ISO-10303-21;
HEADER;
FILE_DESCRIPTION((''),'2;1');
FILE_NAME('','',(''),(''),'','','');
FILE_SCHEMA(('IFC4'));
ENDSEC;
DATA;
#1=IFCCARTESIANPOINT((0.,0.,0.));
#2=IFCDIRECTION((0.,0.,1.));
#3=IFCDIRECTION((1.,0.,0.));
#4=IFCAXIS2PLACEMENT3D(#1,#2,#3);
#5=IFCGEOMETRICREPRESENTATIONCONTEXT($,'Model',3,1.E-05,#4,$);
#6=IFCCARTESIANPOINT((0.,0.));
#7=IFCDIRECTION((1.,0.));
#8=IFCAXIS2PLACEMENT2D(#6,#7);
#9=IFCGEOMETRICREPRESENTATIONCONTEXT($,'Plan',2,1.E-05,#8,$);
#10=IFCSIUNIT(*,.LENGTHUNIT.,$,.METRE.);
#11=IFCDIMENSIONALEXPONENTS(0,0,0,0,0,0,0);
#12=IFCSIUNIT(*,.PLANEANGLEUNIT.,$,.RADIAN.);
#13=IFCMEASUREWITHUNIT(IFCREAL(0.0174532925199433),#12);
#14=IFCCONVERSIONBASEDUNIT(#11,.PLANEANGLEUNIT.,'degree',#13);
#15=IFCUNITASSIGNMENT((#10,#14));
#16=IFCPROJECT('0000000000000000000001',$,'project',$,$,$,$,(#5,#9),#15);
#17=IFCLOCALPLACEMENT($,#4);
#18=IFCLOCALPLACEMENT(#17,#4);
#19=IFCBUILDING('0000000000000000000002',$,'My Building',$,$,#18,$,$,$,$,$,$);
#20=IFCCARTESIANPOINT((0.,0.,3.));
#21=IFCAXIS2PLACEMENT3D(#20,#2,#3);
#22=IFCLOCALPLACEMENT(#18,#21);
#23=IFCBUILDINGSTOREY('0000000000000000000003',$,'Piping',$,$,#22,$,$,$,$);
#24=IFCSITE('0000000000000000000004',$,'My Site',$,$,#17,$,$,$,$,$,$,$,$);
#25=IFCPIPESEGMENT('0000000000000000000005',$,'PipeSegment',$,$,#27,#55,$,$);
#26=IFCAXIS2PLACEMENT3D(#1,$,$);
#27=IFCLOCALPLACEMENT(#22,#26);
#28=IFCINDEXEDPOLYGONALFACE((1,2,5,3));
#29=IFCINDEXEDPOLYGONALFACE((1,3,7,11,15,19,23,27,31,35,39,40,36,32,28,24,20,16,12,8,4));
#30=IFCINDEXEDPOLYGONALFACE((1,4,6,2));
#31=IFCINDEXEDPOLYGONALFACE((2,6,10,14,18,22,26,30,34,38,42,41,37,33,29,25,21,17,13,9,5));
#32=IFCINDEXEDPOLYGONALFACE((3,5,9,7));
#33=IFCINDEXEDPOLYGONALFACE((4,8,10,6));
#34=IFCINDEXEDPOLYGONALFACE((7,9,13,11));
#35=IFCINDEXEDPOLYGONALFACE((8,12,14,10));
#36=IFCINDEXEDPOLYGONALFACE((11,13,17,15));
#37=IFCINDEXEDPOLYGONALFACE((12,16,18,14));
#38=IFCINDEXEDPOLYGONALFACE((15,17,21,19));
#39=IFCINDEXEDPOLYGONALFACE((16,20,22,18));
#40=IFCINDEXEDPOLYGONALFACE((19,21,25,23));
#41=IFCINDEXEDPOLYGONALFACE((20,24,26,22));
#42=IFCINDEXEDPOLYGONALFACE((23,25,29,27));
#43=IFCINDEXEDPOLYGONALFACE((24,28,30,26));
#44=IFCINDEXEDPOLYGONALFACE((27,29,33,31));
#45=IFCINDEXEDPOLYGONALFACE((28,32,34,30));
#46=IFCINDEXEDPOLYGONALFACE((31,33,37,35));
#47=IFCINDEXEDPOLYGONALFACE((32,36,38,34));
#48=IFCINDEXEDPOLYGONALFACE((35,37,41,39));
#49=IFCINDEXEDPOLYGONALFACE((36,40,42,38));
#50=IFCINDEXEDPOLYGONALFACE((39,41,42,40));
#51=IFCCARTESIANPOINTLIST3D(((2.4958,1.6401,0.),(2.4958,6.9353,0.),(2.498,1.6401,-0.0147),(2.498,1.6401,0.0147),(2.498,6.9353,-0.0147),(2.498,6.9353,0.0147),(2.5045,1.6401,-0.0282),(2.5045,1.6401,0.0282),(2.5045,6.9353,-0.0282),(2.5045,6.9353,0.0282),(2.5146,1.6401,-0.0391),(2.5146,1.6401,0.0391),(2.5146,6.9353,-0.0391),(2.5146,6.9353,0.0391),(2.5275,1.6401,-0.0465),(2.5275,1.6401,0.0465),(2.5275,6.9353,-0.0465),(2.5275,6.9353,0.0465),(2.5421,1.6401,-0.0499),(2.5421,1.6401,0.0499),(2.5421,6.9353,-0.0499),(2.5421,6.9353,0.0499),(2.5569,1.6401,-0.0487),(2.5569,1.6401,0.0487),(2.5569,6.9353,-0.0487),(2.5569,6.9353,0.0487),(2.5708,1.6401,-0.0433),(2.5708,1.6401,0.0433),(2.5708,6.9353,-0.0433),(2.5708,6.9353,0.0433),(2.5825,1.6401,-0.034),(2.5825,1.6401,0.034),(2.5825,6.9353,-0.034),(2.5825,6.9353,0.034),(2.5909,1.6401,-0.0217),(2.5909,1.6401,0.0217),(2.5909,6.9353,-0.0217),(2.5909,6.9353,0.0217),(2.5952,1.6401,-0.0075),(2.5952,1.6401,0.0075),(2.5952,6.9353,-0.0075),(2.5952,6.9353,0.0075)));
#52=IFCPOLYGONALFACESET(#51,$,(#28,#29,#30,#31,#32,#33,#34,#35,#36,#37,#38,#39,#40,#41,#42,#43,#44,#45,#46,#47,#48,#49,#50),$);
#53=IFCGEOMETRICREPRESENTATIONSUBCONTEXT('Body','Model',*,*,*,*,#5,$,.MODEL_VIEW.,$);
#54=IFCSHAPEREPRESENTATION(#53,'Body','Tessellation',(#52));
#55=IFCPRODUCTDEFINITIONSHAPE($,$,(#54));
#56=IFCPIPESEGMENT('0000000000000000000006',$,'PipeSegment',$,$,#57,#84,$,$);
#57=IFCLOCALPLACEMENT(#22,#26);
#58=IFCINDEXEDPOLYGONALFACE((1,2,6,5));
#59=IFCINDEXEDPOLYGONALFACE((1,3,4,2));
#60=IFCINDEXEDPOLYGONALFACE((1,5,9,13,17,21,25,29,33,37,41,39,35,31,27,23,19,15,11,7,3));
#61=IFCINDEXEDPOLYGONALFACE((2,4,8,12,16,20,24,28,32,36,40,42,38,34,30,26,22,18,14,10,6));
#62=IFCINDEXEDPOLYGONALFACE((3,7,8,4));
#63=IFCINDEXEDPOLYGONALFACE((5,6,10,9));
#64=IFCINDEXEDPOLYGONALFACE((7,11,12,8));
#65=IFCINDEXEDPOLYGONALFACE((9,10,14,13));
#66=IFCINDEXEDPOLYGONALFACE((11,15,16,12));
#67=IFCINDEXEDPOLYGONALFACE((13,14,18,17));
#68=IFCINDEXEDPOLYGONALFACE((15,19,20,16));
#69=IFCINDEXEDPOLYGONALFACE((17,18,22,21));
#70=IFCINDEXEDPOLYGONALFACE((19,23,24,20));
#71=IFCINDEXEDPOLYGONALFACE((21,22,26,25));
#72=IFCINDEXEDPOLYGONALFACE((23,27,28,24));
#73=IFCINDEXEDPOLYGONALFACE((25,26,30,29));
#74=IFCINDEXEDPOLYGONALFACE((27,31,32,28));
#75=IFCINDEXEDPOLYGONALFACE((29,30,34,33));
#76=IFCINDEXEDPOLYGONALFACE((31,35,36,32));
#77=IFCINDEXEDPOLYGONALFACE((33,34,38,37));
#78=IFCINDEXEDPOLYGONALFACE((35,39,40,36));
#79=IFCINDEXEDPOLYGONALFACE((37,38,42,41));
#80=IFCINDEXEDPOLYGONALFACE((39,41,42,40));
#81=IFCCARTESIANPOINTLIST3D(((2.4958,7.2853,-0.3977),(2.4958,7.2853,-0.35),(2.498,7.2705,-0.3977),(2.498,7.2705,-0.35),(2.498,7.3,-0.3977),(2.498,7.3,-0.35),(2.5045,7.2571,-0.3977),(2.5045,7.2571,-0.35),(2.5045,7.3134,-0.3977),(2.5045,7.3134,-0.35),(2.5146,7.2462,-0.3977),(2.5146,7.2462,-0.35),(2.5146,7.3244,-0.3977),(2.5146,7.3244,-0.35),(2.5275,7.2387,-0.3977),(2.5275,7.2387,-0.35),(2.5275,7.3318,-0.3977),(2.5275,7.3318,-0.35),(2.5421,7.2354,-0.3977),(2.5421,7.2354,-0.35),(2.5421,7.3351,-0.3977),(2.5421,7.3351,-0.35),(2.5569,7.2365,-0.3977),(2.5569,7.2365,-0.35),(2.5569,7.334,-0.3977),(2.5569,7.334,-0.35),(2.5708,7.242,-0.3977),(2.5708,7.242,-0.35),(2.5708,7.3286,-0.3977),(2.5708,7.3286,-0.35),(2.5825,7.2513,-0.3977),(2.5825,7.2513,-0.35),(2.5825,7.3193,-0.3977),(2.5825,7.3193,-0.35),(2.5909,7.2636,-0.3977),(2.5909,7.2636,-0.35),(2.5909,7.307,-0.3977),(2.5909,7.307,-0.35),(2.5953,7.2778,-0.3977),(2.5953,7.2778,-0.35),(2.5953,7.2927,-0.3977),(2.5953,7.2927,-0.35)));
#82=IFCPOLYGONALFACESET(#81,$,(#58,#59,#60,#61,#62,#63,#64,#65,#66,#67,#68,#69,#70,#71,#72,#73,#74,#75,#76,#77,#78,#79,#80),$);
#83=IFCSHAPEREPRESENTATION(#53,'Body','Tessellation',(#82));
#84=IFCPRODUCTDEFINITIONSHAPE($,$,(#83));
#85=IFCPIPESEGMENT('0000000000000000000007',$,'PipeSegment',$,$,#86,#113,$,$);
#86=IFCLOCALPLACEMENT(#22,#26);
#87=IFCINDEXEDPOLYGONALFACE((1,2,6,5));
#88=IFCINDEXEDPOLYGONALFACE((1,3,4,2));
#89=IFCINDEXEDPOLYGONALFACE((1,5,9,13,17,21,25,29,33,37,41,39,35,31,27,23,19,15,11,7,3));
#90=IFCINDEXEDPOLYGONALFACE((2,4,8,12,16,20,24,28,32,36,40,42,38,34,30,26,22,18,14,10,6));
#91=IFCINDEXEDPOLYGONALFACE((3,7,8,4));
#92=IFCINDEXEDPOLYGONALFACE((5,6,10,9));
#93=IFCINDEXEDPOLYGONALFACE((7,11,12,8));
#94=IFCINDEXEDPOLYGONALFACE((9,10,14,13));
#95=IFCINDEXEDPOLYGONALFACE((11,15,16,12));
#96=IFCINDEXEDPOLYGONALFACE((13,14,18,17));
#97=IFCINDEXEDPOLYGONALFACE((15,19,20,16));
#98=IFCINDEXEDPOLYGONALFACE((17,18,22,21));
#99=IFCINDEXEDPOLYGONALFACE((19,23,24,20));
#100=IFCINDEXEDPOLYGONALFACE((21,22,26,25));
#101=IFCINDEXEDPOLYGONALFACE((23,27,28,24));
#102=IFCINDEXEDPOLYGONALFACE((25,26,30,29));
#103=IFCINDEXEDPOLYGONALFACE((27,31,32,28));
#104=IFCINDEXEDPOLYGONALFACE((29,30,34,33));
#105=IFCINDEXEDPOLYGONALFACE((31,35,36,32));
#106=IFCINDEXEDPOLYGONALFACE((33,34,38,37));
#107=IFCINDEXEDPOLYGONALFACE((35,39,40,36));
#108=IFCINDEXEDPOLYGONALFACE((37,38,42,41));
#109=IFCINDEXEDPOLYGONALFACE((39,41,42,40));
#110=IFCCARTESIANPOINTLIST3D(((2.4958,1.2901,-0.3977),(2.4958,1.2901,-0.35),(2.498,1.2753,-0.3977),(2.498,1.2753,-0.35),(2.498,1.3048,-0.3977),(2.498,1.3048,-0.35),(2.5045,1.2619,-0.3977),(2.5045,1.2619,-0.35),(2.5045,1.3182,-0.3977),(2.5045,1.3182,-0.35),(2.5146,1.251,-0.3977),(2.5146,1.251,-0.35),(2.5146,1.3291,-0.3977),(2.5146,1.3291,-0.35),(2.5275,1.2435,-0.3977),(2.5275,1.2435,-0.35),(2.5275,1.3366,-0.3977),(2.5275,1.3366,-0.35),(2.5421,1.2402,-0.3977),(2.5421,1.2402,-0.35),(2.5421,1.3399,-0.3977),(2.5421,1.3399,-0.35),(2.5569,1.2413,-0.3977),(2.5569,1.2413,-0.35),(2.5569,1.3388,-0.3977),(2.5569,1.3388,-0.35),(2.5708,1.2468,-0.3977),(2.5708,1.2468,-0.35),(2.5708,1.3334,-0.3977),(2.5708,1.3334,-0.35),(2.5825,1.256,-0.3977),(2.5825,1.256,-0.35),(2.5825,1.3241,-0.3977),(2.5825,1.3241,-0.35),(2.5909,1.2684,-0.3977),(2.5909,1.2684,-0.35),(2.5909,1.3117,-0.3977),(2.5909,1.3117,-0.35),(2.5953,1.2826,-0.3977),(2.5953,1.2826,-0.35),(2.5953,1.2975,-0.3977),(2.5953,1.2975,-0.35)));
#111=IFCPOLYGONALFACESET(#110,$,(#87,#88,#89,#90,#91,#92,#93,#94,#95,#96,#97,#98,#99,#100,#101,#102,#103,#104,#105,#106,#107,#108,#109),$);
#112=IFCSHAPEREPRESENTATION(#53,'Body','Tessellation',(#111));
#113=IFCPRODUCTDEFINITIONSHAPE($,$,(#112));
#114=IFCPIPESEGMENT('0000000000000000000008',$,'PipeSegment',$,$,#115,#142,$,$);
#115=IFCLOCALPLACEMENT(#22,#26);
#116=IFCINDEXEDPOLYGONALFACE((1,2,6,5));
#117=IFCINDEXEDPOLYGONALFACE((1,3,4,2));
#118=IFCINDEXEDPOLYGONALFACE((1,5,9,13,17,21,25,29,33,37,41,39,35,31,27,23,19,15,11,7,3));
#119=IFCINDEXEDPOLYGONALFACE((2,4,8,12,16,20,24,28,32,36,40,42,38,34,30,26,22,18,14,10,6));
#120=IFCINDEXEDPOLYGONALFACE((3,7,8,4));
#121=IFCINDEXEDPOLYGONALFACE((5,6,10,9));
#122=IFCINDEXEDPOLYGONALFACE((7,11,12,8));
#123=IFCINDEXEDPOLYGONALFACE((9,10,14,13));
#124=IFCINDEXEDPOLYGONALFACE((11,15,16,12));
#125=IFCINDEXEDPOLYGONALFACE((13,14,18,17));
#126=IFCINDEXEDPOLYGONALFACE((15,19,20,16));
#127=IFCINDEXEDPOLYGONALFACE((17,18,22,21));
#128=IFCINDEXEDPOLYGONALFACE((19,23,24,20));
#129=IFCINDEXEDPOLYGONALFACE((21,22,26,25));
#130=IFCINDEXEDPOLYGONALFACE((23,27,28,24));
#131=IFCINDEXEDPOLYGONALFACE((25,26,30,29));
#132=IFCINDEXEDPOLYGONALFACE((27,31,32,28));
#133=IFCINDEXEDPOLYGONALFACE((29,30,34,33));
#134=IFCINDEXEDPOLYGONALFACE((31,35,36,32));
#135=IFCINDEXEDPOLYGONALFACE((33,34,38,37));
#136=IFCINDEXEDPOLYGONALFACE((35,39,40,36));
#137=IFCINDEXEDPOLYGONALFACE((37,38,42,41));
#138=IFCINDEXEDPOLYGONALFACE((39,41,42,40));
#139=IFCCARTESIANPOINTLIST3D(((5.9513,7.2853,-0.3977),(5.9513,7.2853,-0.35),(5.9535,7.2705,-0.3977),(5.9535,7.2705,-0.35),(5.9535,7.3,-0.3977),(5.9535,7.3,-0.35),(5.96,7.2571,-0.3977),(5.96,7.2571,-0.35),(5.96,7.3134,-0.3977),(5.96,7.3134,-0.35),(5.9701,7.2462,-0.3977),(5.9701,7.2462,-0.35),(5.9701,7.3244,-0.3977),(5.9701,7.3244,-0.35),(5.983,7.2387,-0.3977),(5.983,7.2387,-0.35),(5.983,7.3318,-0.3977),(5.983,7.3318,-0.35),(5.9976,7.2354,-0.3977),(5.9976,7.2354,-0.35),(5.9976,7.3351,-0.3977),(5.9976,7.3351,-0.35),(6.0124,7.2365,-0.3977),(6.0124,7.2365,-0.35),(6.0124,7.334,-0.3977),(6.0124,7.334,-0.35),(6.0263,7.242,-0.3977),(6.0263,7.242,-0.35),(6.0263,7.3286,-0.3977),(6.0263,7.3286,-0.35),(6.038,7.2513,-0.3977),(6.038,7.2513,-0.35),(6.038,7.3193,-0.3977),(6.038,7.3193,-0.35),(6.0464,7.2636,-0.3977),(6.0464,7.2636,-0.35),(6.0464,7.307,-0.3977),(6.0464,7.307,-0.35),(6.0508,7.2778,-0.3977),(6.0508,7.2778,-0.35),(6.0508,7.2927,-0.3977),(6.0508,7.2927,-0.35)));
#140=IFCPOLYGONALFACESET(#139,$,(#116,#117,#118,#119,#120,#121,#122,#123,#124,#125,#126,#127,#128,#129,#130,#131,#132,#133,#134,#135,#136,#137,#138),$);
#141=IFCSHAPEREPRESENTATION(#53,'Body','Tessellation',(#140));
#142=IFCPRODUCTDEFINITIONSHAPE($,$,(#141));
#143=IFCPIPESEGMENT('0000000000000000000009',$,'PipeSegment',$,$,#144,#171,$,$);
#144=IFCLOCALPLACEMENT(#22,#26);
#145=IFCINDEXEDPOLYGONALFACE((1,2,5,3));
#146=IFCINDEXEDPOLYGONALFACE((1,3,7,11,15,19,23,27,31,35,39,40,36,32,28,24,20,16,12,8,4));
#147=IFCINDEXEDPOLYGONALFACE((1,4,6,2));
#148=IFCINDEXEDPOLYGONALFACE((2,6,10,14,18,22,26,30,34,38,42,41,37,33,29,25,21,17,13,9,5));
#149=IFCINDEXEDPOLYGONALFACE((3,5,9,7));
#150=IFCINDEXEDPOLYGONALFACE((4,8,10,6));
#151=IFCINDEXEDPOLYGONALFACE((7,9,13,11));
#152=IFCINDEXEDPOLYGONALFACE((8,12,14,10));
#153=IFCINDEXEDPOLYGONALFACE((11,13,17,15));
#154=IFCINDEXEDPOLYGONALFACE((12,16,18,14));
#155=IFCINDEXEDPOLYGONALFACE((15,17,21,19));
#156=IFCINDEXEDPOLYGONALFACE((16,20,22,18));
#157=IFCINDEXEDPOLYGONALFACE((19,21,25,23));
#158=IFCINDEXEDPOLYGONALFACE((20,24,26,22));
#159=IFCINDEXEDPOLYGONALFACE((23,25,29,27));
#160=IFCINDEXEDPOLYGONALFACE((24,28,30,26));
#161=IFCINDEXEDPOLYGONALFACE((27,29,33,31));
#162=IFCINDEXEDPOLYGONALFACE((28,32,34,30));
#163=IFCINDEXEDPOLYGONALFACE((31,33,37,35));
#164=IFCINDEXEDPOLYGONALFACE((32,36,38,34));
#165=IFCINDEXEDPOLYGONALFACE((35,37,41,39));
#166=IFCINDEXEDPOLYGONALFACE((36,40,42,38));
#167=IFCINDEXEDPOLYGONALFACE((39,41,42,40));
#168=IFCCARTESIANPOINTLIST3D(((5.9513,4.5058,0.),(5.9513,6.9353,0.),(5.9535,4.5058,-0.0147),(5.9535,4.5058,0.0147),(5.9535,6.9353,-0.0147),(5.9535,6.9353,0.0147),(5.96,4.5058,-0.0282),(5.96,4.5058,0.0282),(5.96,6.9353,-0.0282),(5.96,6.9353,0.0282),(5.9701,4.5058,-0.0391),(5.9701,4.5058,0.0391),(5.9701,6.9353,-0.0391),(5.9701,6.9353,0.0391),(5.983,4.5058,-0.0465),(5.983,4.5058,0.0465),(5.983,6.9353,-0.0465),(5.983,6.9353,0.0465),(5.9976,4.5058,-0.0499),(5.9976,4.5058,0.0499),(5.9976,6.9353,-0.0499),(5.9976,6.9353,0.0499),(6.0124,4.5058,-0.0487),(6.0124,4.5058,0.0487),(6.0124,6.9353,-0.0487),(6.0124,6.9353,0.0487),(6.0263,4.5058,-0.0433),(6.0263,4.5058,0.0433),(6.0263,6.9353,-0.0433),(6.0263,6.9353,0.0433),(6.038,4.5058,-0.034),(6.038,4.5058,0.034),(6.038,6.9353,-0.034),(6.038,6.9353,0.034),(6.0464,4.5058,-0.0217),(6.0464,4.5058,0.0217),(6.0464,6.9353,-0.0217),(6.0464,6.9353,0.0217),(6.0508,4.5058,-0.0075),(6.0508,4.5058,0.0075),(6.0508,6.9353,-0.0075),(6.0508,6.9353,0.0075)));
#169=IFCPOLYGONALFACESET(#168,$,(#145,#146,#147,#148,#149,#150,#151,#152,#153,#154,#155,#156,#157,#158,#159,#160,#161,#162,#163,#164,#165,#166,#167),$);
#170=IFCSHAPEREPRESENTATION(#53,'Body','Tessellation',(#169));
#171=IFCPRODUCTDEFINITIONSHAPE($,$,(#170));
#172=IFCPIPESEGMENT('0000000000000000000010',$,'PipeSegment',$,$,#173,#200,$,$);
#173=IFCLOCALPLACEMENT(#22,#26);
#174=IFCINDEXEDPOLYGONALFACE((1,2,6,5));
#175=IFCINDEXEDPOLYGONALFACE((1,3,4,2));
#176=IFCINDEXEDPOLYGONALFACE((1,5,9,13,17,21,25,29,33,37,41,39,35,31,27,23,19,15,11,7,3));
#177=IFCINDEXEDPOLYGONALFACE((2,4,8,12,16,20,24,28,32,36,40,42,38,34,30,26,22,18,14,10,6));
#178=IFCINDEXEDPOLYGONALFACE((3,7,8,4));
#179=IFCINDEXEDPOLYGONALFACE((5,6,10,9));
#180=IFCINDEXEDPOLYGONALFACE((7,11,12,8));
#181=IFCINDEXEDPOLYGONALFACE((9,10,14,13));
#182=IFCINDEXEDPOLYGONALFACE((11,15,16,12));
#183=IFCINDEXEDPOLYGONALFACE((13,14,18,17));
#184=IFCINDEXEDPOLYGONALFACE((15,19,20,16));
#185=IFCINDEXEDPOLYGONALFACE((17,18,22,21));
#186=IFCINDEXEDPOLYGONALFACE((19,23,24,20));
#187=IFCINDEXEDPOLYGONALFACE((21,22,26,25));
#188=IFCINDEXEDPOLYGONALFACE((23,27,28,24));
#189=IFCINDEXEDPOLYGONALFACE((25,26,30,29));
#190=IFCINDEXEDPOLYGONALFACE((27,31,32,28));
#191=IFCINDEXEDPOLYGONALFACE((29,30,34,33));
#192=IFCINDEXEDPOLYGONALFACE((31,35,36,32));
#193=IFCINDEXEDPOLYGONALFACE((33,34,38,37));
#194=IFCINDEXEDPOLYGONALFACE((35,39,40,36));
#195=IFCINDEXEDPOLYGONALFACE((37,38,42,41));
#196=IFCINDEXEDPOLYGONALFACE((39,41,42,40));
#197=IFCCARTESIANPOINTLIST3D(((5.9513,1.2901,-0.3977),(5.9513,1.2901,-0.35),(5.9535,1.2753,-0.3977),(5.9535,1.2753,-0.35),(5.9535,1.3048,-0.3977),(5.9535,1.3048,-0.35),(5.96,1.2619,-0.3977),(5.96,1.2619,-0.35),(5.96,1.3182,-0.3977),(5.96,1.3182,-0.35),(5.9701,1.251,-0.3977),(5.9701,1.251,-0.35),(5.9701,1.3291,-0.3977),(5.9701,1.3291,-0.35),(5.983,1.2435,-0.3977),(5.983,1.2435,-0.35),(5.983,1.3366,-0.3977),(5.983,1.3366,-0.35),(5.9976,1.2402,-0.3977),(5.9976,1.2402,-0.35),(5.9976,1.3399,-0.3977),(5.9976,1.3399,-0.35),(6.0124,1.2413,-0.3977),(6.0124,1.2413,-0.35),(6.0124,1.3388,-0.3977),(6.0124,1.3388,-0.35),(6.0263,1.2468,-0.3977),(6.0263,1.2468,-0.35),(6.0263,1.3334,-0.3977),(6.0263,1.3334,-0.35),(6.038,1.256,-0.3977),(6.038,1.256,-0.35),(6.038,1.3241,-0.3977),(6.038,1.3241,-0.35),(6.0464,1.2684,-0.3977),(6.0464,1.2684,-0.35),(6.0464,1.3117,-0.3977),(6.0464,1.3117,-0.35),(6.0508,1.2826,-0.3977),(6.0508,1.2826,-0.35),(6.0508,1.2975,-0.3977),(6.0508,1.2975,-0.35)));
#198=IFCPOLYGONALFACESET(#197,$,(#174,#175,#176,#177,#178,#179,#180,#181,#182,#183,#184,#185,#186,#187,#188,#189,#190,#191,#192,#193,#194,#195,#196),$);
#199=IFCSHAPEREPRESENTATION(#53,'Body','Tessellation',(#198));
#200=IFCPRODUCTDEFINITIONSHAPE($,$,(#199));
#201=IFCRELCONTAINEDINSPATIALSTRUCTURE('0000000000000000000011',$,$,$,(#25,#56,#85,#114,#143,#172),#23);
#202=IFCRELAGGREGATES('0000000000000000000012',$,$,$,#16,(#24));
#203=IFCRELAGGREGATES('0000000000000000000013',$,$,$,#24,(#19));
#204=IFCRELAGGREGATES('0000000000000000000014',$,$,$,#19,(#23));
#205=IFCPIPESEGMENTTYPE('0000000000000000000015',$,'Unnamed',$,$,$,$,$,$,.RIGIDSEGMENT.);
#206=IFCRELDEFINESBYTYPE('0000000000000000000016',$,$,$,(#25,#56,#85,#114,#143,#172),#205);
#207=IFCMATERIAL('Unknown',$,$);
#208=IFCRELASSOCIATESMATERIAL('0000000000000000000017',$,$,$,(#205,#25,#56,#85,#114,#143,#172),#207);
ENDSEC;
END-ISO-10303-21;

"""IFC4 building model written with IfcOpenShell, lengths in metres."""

from ifc_helpers import new_model, entity, si_unit, converted_unit, frame, origin_with_axes, origin_2d_with_axis, place, context, subcontext, project, spatial, circle, extrude, material, material_profile, profile_set, profile_usage, type_object, element, save


model = new_model("IFC4")

# Units and contexts
model_context = context("Model", 3, precision=1e-05, world=origin_with_axes())
plan_context = context("Plan", 2, precision=1e-05, world=origin_2d_with_axis())
body_context = subcontext(model_context, "Body", "Model", "MODEL_VIEW")
ifc_project = project(units=[si_unit("LENGTHUNIT", "METRE"), converted_unit("PLANEANGLEUNIT", "degree", entity("IfcReal", 0.0174532925199433), si_unit("PLANEANGLEUNIT", "RADIAN"), dimensions=[0, 0, 0, 0, 0, 0, 0])], contexts=[model_context, plan_context])

# Site, building, storey
site_placement = place(None, origin_with_axes())
site = spatial("IfcSite", under=ifc_project, at=site_placement, Name="My Site")
building_placement = place(site_placement, origin_with_axes())
building = spatial("IfcBuilding", under=site, at=building_placement, Name="My Building")
storey_placement = place(building_placement, frame((0.0, 0.0, 3.0), z_axis=(0.0, 0.0, 1.0), x_axis=(1.0, 0.0, 0.0)))
storey = spatial("IfcBuildingStorey", under=building, at=storey_placement, Name="Piping")

# Pipe segments
ifc_material = material(Name="Unknown")
ifc_material_profile_1 = material_profile(ifc_material, circle(Radius=0.05))
ifc_profile_set_1 = profile_set([ifc_material_profile_1])
ifc_profile_usage_1 = profile_usage(ifc_profile_set_1, cardinal=5)
pipe_segment_type = type_object("IfcPipeSegmentType", Name="Unnamed", PredefinedType="RIGIDSEGMENT", material=ifc_profile_set_1)
pipe_segment_1_placement = place(storey_placement, frame((2.5458, 6.9353, 0.0), z_axis=(0.0, -1.0, 0.0), x_axis=(-1.0, 0.0, 0.0)))
element("IfcPipeSegment", 1, at=pipe_segment_1_placement, inside=storey, type_object=pipe_segment_type, material=ifc_profile_usage_1, Name="PipeSegment", context=body_context, shape_type="SweptSolid", body=[
    extrude(circle(Radius=0.05), origin_with_axes(), (0.0, 0.0, 1.0), 5.2952),
])
ifc_profile_usage_2 = profile_usage(ifc_profile_set_1, cardinal=5)
pipe_segment_2_placement = place(storey_placement, frame((2.5458, 7.2853, -0.35), z_axis=(0.0, 0.0, -1.0), x_axis=(-1.0, 0.0, 0.0)))
element("IfcPipeSegment", 2, at=pipe_segment_2_placement, inside=storey, type_object=pipe_segment_type, material=ifc_profile_usage_2, Name="PipeSegment", context=body_context, shape_type="SweptSolid", body=[
    extrude(circle(Radius=0.05), origin_with_axes(), (0.0, 0.0, 1.0), 0.0477),
])
ifc_profile_usage_3 = profile_usage(ifc_profile_set_1, cardinal=5)
pipe_segment_3_placement = place(storey_placement, frame((2.5458, 1.2901, -0.35), z_axis=(0.0, 0.0, -1.0), x_axis=(-1.0, 0.0, 0.0)))
element("IfcPipeSegment", 3, at=pipe_segment_3_placement, inside=storey, type_object=pipe_segment_type, material=ifc_profile_usage_3, Name="PipeSegment", context=body_context, shape_type="SweptSolid", body=[
    extrude(circle(Radius=0.05), origin_with_axes(), (0.0, 0.0, 1.0), 0.0477),
])
ifc_profile_usage_4 = profile_usage(ifc_profile_set_1, cardinal=5)
pipe_segment_4_placement = place(storey_placement, frame((6.0013, 7.2853, -0.35), z_axis=(0.0, 0.0, -1.0), x_axis=(-1.0, 0.0, 0.0)))
element("IfcPipeSegment", 4, at=pipe_segment_4_placement, inside=storey, type_object=pipe_segment_type, material=ifc_profile_usage_4, Name="PipeSegment", context=body_context, shape_type="SweptSolid", body=[
    extrude(circle(Radius=0.05), origin_with_axes(), (0.0, 0.0, 1.0), 0.0477),
])
ifc_profile_usage_5 = profile_usage(ifc_profile_set_1, cardinal=5)
pipe_segment_5_placement = place(storey_placement, frame((6.0013, 6.9353, 0.0), z_axis=(0.0, -1.0, 0.0), x_axis=(-1.0, 0.0, 0.0)))
element("IfcPipeSegment", 5, at=pipe_segment_5_placement, inside=storey, type_object=pipe_segment_type, material=ifc_profile_usage_5, Name="PipeSegment", context=body_context, shape_type="SweptSolid", body=[
    extrude(circle(Radius=0.05), origin_with_axes(), (0.0, 0.0, 1.0), 2.4294),
])
ifc_profile_usage_6 = profile_usage(ifc_profile_set_1, cardinal=5)
pipe_segment_6_placement = place(storey_placement, frame((6.0013, 1.2901, -0.35), z_axis=(0.0, 0.0, -1.0), x_axis=(-1.0, 0.0, 0.0)))
element("IfcPipeSegment", 6, at=pipe_segment_6_placement, inside=storey, type_object=pipe_segment_type, material=ifc_profile_usage_6, Name="PipeSegment", context=body_context, shape_type="SweptSolid", body=[
    extrude(circle(Radius=0.05), origin_with_axes(), (0.0, 0.0, 1.0), 0.0477),
])

save(model, "model.ifc")
